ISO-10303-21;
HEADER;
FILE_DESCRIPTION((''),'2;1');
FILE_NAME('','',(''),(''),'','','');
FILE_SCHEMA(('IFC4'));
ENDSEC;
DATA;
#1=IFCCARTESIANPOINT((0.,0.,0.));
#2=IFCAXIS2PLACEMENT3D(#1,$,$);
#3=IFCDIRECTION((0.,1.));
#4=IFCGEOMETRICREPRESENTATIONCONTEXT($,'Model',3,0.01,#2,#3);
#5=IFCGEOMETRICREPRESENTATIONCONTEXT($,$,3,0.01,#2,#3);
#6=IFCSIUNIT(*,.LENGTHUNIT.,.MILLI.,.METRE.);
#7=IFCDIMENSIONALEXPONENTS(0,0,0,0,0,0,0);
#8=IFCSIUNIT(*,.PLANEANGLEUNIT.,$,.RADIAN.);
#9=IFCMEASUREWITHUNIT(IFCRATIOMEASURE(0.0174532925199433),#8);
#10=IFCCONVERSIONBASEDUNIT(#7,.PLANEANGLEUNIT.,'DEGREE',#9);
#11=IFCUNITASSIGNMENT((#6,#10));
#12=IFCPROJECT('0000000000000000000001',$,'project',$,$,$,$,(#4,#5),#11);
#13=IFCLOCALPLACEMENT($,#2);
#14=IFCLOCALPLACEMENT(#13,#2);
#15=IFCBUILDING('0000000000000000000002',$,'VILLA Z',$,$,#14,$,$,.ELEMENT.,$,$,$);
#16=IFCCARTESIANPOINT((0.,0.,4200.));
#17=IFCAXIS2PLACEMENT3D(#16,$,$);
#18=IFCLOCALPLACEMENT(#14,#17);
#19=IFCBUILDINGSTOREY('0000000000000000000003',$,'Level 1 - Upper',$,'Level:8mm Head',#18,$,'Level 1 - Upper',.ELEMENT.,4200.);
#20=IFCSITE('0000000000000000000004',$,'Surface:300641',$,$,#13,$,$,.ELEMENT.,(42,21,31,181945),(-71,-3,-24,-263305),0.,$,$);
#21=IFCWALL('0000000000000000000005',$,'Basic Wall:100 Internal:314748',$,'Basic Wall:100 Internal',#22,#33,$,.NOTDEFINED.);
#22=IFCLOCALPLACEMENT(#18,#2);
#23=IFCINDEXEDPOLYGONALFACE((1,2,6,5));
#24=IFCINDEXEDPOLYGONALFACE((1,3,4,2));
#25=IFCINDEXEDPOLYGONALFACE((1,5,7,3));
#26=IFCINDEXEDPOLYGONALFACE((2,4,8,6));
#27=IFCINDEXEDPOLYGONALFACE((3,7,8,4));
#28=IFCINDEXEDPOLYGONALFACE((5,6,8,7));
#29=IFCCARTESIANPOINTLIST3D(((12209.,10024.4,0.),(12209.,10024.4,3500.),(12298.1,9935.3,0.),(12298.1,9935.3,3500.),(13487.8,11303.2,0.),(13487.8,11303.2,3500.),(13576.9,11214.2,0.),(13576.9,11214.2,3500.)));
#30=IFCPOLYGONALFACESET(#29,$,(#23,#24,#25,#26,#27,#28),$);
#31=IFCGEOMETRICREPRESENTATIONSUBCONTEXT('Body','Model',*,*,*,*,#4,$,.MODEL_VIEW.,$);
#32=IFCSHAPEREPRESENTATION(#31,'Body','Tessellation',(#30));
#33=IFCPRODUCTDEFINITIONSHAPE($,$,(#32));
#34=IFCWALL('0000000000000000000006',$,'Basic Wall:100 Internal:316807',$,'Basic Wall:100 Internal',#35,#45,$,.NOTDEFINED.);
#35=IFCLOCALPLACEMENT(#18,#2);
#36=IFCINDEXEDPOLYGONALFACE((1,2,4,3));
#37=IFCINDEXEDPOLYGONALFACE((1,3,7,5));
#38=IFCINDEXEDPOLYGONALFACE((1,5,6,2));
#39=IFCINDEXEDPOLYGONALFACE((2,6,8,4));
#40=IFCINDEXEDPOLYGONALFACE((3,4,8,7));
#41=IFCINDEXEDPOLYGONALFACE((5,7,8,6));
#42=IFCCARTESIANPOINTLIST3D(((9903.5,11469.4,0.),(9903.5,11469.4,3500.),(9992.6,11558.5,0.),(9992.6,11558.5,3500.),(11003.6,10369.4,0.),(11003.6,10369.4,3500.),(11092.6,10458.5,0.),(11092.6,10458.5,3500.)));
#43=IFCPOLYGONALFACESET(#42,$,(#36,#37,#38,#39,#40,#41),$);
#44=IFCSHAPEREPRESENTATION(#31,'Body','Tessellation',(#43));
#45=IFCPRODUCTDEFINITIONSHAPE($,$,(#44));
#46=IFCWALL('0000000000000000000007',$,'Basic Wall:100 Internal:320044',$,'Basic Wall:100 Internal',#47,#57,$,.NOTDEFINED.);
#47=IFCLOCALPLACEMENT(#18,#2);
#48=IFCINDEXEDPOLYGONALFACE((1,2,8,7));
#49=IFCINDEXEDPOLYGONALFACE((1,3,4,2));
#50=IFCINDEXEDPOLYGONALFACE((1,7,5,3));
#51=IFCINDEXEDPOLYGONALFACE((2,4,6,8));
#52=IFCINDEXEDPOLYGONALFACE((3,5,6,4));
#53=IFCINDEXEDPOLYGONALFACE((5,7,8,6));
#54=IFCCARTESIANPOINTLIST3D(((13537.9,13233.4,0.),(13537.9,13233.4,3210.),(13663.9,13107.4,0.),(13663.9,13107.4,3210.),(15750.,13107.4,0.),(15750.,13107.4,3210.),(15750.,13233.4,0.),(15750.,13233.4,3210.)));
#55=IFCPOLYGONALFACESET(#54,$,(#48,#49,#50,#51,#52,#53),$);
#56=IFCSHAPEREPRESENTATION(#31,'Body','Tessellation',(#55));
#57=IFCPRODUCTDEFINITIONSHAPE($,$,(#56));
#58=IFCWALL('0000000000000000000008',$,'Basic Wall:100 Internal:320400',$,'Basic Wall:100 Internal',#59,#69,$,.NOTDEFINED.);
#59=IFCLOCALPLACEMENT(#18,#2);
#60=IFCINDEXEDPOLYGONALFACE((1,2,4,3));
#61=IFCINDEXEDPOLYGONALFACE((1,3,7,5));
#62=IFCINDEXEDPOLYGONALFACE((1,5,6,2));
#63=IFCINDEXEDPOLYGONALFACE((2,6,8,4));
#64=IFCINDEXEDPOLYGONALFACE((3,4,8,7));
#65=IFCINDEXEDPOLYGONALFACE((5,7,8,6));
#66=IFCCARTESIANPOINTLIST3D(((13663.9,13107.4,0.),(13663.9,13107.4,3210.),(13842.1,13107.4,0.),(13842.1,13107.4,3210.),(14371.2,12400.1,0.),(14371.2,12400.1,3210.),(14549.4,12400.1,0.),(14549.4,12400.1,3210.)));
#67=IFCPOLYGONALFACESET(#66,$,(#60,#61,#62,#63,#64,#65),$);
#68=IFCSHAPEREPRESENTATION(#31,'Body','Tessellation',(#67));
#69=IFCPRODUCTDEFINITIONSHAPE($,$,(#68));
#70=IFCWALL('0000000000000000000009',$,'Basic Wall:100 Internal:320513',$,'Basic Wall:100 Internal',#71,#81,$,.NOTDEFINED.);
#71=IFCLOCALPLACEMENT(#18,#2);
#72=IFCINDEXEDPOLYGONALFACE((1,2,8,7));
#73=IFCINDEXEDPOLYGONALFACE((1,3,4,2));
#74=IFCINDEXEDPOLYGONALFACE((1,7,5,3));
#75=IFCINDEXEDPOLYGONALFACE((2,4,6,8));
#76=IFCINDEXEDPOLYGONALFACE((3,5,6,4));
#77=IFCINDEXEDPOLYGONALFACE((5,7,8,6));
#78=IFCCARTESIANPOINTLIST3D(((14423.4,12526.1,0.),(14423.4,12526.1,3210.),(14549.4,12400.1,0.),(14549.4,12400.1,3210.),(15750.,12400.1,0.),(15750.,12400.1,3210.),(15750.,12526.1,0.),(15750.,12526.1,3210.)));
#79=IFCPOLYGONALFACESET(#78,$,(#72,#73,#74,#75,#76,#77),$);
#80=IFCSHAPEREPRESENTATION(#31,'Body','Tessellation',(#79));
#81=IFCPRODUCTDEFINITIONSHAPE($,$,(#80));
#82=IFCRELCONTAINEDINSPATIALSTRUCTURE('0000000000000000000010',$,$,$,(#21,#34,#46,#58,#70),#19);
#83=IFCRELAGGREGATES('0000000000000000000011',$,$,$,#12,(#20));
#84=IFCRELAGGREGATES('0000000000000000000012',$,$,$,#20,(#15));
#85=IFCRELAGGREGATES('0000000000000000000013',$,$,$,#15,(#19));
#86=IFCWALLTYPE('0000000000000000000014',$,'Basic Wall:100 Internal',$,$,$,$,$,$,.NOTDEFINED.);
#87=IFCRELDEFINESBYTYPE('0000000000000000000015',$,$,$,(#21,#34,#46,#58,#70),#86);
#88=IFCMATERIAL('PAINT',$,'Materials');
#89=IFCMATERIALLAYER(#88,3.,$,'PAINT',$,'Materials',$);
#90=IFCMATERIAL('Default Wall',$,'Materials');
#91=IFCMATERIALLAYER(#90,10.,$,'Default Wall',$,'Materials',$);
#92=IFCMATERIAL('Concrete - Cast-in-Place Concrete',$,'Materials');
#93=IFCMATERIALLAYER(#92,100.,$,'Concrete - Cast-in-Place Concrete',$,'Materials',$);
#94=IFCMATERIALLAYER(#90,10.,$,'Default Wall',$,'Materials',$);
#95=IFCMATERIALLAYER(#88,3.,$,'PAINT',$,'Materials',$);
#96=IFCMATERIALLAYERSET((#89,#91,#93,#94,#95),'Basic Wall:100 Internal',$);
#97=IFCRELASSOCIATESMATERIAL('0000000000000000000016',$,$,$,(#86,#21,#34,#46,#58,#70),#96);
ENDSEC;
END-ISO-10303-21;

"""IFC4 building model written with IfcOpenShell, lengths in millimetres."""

from ifc_helpers import new_model, entity, si_unit, converted_unit, direction, frame, frame_2d, origin, place, context, subcontext, project, spatial, polyline, rectangle, outline, extrude, clip, halfspace, bounded_halfspace, material, layer, layer_set, layer_usage, type_object, element, save


model = new_model("IFC4")

# Units and contexts
model_context = context("Model", 3, precision=0.01, world=origin(), true_north=direction((0.0, 1.0)))
context_of_model = context(None, 3, precision=0.01, world=origin(), true_north=direction((0.0, 1.0)))
body_context = subcontext(model_context, "Body", "Model", "MODEL_VIEW")
ifc_project = project(units=[si_unit("LENGTHUNIT", "METRE", prefix="MILLI"), converted_unit("PLANEANGLEUNIT", "DEGREE", entity("IfcRatioMeasure", 0.0174532925199433), si_unit("PLANEANGLEUNIT", "RADIAN"), dimensions=[0, 0, 0, 0, 0, 0, 0])], contexts=[model_context, context_of_model])

# Site, building, storey
site_placement = place(None, origin())
site = spatial("IfcSite", under=ifc_project, at=site_placement, Name="Surface:300641", CompositionType="ELEMENT", RefLatitude=(42, 21, 31, 181945), RefLongitude=(-71, -3, -24, -263305), RefElevation=0.0)
building_placement = place(site_placement, origin())
building = spatial("IfcBuilding", under=site, at=building_placement, Name="VILLA Z", CompositionType="ELEMENT")
storey_placement = place(building_placement, frame((0.0, 0.0, 4200.0)))
storey = spatial("IfcBuildingStorey", under=building, at=storey_placement, Name="Level 1 - Upper", ObjectType="Level:8mm Head", LongName="Level 1 - Upper", CompositionType="ELEMENT", Elevation=4200.0)

# Shared definitions
ifc_material_1 = material(Name="PAINT", Category="Materials")
ifc_material_2 = material(Name="Concrete - Cast-in-Place Concrete", Category="Materials")
ifc_material_3 = material(Name="Default Wall", Category="Materials")

# Walls
ifc_layer_1 = layer(ifc_material_1, 3.0, Name="PAINT", Category="Materials")
ifc_layer_2 = layer(ifc_material_3, 10.0, Name="Default Wall", Category="Materials")
ifc_layer_3 = layer(ifc_material_2, 100.0, Name="Concrete - Cast-in-Place Concrete", Category="Materials")
ifc_layer_4 = layer(ifc_material_3, 10.0, Name="Default Wall", Category="Materials")
ifc_layer_5 = layer(ifc_material_1, 3.0, Name="PAINT", Category="Materials")
ifc_layer_set_1 = layer_set([ifc_layer_1, ifc_layer_2, ifc_layer_3, ifc_layer_4, ifc_layer_5], Name="Basic Wall:100 Internal")
ifc_layer_usage_1 = layer_usage(ifc_layer_set_1, "AXIS2", "NEGATIVE", 63.0)
wall_type_1 = type_object("IfcWallType", Name="Basic Wall:100 Internal", PredefinedType="NOTDEFINED", material=ifc_layer_set_1)
wall_1_placement = place(storey_placement, frame((13532.4, 11258.7, 0.0), z_axis=(0.0, 0.0, 1.0), x_axis=(-0.707107, -0.707107, 0.0)))
element("IfcWall", 1, at=wall_1_placement, inside=storey, type_object=wall_type_1, material=ifc_layer_usage_1, Name="Basic Wall:100 Internal:314748", ObjectType="Basic Wall:100 Internal", PredefinedType="NOTDEFINED", context=body_context, shape_type="Clipping", body=[
    clip(extrude(rectangle(XDim=1808.6, YDim=126.0, at=frame_2d((904.3, 0.0), x_axis=(-1.0, 0.0))), origin(), (0.0, 0.0, 1.0), 3500.0), halfspace(origin(), True)),
])
ifc_layer_usage_2 = layer_usage(ifc_layer_set_1, "AXIS2", "NEGATIVE", 63.0)
wall_2_placement = place(storey_placement, frame((9948.0, 11514.0, 0.0), z_axis=(0.0, 0.0, 1.0), x_axis=(0.707107, -0.707107, 0.0)))
element("IfcWall", 2, at=wall_2_placement, inside=storey, type_object=wall_type_1, material=ifc_layer_usage_2, Name="Basic Wall:100 Internal:316807", ObjectType="Basic Wall:100 Internal", PredefinedType="NOTDEFINED", context=body_context, shape_type="Clipping", body=[
    clip(extrude(rectangle(XDim=1555.7, YDim=126.0, at=frame_2d((777.9, 0.0), x_axis=(-1.0, 0.0))), origin(), (0.0, 0.0, 1.0), 3500.0), halfspace(origin(), True)),
])

# Walls
ifc_layer_usage_3 = layer_usage(ifc_layer_set_1, "AXIS2", "NEGATIVE", 63.0)
wall_3_placement = place(storey_placement, frame((15750.0, 13170.4, 0.0), z_axis=(0.0, 0.0, 1.0), x_axis=(-1.0, 0.0, 0.0)))
element("IfcWall", 3, at=wall_3_placement, inside=storey, type_object=wall_type_1, material=ifc_layer_usage_3, Name="Basic Wall:100 Internal:320044", ObjectType="Basic Wall:100 Internal", PredefinedType="NOTDEFINED", context=body_context, shape_type="Clipping", body=[
    clip(clip(extrude(outline(polyline([(2212.1, -63.0), (2086.1, 63.0), (1907.9, 63.0), (0.0, 63.0), (0.0, -63.0), (2212.1, -63.0)])), origin(), (0.0, 0.0, 1.0), 3210.0), bounded_halfspace(frame((0.0, -63.0, 3210.0), z_axis=(0.0, 0.0, -1.0), x_axis=(0.0, 1.0, 0.0)), True, frame((0.0, -63.0, 3210.0)), polyline([(0.0, 0.0), (2212.1, 0.0), (2086.1, 126.0), (1907.9, 126.0), (0.0, 126.0), (0.0, 0.0)]))), halfspace(frame((0.0, 0.0, -400.0)), True)),
])
ifc_layer_usage_4 = layer_usage(ifc_layer_set_1, "AXIS2", "NEGATIVE", 63.0)
wall_4_placement = place(storey_placement, frame((13708.5, 13152.0, 0.0), z_axis=(0.0, 0.0, 1.0), x_axis=(0.707107, -0.707107, 0.0)))
element("IfcWall", 4, at=wall_4_placement, inside=storey, type_object=wall_type_1, material=ifc_layer_usage_4, Name="Basic Wall:100 Internal:320400", ObjectType="Basic Wall:100 Internal", PredefinedType="NOTDEFINED", context=body_context, shape_type="Clipping", body=[
    clip(clip(extrude(outline(polyline([(1000.3, -63.0), (1126.3, 63.0), (948.1, 63.0), (126.0, 63.0), (0.0, -63.0), (1000.3, -63.0)])), origin(), (0.0, 0.0, 1.0), 3210.0), bounded_halfspace(frame((0.0, -63.0, 3210.0), z_axis=(0.0, 0.0, -1.0), x_axis=(0.707107, -0.707107, 0.0)), True, frame((0.0, -63.0, 3210.0)), polyline([(0.0, 0.0), (1000.3, 0.0), (1126.3, 126.0), (948.1, 126.0), (126.0, 126.0), (0.0, 0.0)]))), halfspace(frame((0.0, 0.0, -400.0)), True)),
])
ifc_layer_usage_5 = layer_usage(ifc_layer_set_1, "AXIS2", "NEGATIVE", 63.0)
wall_5_placement = place(storey_placement, frame((14423.4, 12463.1, 0.0)))
element("IfcWall", 5, at=wall_5_placement, inside=storey, type_object=wall_type_1, material=ifc_layer_usage_5, Name="Basic Wall:100 Internal:320513", ObjectType="Basic Wall:100 Internal", PredefinedType="NOTDEFINED", context=body_context, shape_type="Clipping", body=[
    clip(clip(extrude(outline(polyline([(1326.6, -63.0), (1326.6, 63.0), (0.0, 63.0), (126.0, -63.0), (1326.6, -63.0)])), origin(), (0.0, 0.0, 1.0), 3210.0), bounded_halfspace(frame((126.0, -63.0, 3210.0), z_axis=(0.0, 0.0, -1.0), x_axis=(0.0, -1.0, 0.0)), True, frame((126.0, -63.0, 3210.0)), polyline([(0.0, 0.0), (1200.6, 0.0), (1200.6, 126.0), (-126.0, 126.0), (0.0, 0.0)]))), halfspace(frame((0.0, 0.0, -400.0)), True)),
])

save(model, "model.ifc")
